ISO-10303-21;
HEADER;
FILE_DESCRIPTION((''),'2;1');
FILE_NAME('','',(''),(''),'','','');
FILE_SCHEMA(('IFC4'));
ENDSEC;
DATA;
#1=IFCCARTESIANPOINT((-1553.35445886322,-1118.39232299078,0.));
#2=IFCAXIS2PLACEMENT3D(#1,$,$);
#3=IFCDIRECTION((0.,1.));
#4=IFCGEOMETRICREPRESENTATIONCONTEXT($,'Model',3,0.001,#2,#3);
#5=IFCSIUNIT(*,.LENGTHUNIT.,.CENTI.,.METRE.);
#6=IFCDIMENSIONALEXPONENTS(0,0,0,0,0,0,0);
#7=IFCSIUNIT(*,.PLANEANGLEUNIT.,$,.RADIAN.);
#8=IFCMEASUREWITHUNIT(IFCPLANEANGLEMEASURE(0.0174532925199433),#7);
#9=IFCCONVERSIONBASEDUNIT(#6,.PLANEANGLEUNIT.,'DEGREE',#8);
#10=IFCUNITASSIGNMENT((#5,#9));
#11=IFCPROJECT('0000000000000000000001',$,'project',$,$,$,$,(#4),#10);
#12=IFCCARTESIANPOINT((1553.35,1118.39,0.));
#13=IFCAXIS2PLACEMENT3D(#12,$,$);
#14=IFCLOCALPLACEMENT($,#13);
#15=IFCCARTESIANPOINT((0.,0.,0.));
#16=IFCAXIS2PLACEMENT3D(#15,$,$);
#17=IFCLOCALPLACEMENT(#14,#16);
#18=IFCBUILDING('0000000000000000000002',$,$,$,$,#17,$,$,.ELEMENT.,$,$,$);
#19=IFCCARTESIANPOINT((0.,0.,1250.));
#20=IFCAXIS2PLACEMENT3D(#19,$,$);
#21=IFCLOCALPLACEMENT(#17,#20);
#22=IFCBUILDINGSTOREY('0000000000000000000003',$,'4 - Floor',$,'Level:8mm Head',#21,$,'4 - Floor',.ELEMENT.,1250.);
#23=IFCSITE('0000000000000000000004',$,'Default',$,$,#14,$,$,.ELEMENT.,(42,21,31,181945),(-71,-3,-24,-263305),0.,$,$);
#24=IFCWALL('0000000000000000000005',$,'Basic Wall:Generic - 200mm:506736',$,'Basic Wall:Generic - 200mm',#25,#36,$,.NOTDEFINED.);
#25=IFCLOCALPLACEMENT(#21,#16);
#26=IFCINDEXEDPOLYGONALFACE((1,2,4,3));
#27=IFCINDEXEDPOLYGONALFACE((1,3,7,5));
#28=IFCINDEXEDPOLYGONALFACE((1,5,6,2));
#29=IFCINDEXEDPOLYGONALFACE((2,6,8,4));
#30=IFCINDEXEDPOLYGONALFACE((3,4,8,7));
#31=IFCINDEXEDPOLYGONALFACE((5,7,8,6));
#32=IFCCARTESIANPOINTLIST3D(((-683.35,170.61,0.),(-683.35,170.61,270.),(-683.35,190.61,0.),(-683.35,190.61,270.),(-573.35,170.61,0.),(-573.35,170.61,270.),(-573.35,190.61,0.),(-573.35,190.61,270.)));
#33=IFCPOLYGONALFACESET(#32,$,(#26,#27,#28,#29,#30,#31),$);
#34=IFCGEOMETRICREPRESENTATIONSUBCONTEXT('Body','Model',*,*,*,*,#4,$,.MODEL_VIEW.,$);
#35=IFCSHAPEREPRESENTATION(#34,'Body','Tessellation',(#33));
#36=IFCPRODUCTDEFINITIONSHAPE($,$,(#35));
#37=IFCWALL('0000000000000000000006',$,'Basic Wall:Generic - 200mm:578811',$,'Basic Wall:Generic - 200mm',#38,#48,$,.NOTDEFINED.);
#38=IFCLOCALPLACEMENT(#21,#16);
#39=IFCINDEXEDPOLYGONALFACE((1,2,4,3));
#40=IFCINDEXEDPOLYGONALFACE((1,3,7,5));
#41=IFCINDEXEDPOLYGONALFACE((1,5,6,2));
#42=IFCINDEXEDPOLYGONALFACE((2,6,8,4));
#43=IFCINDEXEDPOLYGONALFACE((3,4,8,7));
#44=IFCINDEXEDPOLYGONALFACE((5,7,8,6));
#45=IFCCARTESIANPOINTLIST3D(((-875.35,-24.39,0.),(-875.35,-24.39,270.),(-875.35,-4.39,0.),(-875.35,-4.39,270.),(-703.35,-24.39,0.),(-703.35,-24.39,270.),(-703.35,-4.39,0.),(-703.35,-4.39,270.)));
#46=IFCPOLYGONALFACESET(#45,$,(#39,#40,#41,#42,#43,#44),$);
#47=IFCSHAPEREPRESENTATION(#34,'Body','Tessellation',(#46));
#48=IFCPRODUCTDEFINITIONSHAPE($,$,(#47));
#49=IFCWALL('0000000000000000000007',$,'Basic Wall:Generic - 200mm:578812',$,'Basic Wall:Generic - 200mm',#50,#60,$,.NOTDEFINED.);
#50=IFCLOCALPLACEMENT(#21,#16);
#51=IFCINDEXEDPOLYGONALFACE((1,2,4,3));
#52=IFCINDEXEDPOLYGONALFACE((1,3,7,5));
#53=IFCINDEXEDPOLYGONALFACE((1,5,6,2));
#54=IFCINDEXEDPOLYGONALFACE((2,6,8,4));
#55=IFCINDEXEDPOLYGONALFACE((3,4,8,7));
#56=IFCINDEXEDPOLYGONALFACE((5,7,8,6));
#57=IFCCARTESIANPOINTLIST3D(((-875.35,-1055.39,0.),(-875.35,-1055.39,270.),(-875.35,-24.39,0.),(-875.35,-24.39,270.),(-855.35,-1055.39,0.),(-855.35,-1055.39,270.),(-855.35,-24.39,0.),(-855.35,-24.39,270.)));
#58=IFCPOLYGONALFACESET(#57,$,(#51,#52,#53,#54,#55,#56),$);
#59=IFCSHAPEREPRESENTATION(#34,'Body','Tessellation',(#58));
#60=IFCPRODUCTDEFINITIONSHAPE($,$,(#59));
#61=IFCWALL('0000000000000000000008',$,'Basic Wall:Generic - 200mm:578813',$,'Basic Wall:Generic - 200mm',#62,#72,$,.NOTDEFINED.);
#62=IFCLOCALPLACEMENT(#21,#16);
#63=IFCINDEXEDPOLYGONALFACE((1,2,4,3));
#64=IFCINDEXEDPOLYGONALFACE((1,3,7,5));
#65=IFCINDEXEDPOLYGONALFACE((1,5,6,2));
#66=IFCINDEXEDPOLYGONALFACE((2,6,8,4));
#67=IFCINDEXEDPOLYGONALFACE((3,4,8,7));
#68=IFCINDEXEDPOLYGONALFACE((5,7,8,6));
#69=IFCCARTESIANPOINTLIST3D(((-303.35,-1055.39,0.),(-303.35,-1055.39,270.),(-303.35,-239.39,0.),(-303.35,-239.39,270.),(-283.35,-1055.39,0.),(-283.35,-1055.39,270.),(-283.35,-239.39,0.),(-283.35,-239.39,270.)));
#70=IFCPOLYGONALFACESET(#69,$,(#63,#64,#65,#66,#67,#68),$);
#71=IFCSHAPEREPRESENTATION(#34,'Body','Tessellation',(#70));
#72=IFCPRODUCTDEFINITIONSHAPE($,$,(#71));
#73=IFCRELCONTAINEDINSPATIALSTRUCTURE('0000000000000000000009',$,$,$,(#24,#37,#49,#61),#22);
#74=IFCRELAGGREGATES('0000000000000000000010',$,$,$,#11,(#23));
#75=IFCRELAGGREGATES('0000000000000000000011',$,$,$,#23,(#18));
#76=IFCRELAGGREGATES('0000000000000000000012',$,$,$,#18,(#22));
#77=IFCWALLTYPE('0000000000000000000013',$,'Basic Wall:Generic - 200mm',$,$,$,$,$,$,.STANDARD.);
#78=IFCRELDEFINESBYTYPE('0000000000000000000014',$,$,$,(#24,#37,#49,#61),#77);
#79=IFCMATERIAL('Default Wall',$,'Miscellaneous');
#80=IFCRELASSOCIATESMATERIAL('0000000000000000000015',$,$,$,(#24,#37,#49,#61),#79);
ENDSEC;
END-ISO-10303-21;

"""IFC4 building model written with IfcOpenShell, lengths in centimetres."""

from ifc_helpers import new_model, entity, si_unit, converted_unit, direction, frame, origin, place, context, subcontext, project, spatial, indexed_curve, outline, extrude, material, type_object, element, save


model = new_model("IFC4")

# Units and contexts
model_context = context("Model", 3, precision=0.001, world=frame((-1553.35445886322, -1118.39232299078, 0.0)), true_north=direction((0.0, 1.0)))
body_context = subcontext(model_context, "Body", "Model", "MODEL_VIEW")
ifc_project = project(units=[si_unit("LENGTHUNIT", "METRE", prefix="CENTI"), converted_unit("PLANEANGLEUNIT", "DEGREE", entity("IfcPlaneAngleMeasure", 0.0174532925199433), si_unit("PLANEANGLEUNIT", "RADIAN"), dimensions=[0, 0, 0, 0, 0, 0, 0])], contexts=[model_context])

# Site, building, storey
site_placement = place(None, frame((1553.35, 1118.39, 0.0)))
site = spatial("IfcSite", under=ifc_project, at=site_placement, Name="Default", CompositionType="ELEMENT", RefLatitude=(42, 21, 31, 181945), RefLongitude=(-71, -3, -24, -263305), RefElevation=0.0)
building_placement = place(site_placement, origin())
building = spatial("IfcBuilding", under=site, at=building_placement, CompositionType="ELEMENT")
storey_placement = place(building_placement, frame((0.0, 0.0, 1250.0)))
storey = spatial("IfcBuildingStorey", under=building, at=storey_placement, Name="4 - Floor", ObjectType="Level:8mm Head", LongName="4 - Floor", CompositionType="ELEMENT", Elevation=1250.0)

# Walls
ifc_material_1 = material(Name="Default Wall", Category="Miscellaneous")
wall_type_1 = type_object("IfcWallType", Name="Basic Wall:Generic - 200mm", PredefinedType="STANDARD")
wall_1_placement = place(storey_placement, frame((-683.35, 180.61, 0.0)))
element("IfcWall", 1, at=wall_1_placement, inside=storey, type_object=wall_type_1, material=ifc_material_1, Name="Basic Wall:Generic - 200mm:506736", ObjectType="Basic Wall:Generic - 200mm", PredefinedType="NOTDEFINED", context=body_context, shape_type="SweptSolid", body=[
    extrude(outline(indexed_curve([(110.0, 10.0), (0.0, 10.0), (0.0, -10.0), (110.0, -10.0), (110.0, 10.0)], self_intersect=False)), origin(), (0.0, 0.0, 1.0), 270.0),
])
wall_2_placement = place(storey_placement, frame((-703.35, -14.39, 0.0), z_axis=(0.0, 0.0, 1.0), x_axis=(-1.0, 0.0, 0.0)))
element("IfcWall", 2, at=wall_2_placement, inside=storey, type_object=wall_type_1, material=ifc_material_1, Name="Basic Wall:Generic - 200mm:578811", ObjectType="Basic Wall:Generic - 200mm", PredefinedType="NOTDEFINED", context=body_context, shape_type="SweptSolid", body=[
    extrude(outline(indexed_curve([(172.0, 10.0), (0.0, 10.0), (0.0, -10.0), (172.0, -10.0), (172.0, 10.0)], self_intersect=False)), origin(), (0.0, 0.0, 1.0), 270.0),
])
wall_3_placement = place(storey_placement, frame((-865.35, -24.39, 0.0), z_axis=(0.0, 0.0, 1.0), x_axis=(0.0, -1.0, 0.0)))
element("IfcWall", 3, at=wall_3_placement, inside=storey, type_object=wall_type_1, material=ifc_material_1, Name="Basic Wall:Generic - 200mm:578812", ObjectType="Basic Wall:Generic - 200mm", PredefinedType="NOTDEFINED", context=body_context, shape_type="SweptSolid", body=[
    extrude(outline(indexed_curve([(1031.0, 10.0), (0.0, 10.0), (0.0, -10.0), (1031.0, -10.0), (1031.0, 10.0)], self_intersect=False)), origin(), (0.0, 0.0, 1.0), 270.0),
])
wall_4_placement = place(storey_placement, frame((-293.35, -239.39, 0.0), z_axis=(0.0, 0.0, 1.0), x_axis=(0.0, -1.0, 0.0)))
element("IfcWall", 4, at=wall_4_placement, inside=storey, type_object=wall_type_1, material=ifc_material_1, Name="Basic Wall:Generic - 200mm:578813", ObjectType="Basic Wall:Generic - 200mm", PredefinedType="NOTDEFINED", context=body_context, shape_type="SweptSolid", body=[
    extrude(outline(indexed_curve([(816.0, 10.0), (0.0, 10.0), (0.0, -10.0), (816.0, -10.0), (816.0, 10.0)], self_intersect=False)), origin(), (0.0, 0.0, 1.0), 270.0),
])

save(model, "model.ifc")
